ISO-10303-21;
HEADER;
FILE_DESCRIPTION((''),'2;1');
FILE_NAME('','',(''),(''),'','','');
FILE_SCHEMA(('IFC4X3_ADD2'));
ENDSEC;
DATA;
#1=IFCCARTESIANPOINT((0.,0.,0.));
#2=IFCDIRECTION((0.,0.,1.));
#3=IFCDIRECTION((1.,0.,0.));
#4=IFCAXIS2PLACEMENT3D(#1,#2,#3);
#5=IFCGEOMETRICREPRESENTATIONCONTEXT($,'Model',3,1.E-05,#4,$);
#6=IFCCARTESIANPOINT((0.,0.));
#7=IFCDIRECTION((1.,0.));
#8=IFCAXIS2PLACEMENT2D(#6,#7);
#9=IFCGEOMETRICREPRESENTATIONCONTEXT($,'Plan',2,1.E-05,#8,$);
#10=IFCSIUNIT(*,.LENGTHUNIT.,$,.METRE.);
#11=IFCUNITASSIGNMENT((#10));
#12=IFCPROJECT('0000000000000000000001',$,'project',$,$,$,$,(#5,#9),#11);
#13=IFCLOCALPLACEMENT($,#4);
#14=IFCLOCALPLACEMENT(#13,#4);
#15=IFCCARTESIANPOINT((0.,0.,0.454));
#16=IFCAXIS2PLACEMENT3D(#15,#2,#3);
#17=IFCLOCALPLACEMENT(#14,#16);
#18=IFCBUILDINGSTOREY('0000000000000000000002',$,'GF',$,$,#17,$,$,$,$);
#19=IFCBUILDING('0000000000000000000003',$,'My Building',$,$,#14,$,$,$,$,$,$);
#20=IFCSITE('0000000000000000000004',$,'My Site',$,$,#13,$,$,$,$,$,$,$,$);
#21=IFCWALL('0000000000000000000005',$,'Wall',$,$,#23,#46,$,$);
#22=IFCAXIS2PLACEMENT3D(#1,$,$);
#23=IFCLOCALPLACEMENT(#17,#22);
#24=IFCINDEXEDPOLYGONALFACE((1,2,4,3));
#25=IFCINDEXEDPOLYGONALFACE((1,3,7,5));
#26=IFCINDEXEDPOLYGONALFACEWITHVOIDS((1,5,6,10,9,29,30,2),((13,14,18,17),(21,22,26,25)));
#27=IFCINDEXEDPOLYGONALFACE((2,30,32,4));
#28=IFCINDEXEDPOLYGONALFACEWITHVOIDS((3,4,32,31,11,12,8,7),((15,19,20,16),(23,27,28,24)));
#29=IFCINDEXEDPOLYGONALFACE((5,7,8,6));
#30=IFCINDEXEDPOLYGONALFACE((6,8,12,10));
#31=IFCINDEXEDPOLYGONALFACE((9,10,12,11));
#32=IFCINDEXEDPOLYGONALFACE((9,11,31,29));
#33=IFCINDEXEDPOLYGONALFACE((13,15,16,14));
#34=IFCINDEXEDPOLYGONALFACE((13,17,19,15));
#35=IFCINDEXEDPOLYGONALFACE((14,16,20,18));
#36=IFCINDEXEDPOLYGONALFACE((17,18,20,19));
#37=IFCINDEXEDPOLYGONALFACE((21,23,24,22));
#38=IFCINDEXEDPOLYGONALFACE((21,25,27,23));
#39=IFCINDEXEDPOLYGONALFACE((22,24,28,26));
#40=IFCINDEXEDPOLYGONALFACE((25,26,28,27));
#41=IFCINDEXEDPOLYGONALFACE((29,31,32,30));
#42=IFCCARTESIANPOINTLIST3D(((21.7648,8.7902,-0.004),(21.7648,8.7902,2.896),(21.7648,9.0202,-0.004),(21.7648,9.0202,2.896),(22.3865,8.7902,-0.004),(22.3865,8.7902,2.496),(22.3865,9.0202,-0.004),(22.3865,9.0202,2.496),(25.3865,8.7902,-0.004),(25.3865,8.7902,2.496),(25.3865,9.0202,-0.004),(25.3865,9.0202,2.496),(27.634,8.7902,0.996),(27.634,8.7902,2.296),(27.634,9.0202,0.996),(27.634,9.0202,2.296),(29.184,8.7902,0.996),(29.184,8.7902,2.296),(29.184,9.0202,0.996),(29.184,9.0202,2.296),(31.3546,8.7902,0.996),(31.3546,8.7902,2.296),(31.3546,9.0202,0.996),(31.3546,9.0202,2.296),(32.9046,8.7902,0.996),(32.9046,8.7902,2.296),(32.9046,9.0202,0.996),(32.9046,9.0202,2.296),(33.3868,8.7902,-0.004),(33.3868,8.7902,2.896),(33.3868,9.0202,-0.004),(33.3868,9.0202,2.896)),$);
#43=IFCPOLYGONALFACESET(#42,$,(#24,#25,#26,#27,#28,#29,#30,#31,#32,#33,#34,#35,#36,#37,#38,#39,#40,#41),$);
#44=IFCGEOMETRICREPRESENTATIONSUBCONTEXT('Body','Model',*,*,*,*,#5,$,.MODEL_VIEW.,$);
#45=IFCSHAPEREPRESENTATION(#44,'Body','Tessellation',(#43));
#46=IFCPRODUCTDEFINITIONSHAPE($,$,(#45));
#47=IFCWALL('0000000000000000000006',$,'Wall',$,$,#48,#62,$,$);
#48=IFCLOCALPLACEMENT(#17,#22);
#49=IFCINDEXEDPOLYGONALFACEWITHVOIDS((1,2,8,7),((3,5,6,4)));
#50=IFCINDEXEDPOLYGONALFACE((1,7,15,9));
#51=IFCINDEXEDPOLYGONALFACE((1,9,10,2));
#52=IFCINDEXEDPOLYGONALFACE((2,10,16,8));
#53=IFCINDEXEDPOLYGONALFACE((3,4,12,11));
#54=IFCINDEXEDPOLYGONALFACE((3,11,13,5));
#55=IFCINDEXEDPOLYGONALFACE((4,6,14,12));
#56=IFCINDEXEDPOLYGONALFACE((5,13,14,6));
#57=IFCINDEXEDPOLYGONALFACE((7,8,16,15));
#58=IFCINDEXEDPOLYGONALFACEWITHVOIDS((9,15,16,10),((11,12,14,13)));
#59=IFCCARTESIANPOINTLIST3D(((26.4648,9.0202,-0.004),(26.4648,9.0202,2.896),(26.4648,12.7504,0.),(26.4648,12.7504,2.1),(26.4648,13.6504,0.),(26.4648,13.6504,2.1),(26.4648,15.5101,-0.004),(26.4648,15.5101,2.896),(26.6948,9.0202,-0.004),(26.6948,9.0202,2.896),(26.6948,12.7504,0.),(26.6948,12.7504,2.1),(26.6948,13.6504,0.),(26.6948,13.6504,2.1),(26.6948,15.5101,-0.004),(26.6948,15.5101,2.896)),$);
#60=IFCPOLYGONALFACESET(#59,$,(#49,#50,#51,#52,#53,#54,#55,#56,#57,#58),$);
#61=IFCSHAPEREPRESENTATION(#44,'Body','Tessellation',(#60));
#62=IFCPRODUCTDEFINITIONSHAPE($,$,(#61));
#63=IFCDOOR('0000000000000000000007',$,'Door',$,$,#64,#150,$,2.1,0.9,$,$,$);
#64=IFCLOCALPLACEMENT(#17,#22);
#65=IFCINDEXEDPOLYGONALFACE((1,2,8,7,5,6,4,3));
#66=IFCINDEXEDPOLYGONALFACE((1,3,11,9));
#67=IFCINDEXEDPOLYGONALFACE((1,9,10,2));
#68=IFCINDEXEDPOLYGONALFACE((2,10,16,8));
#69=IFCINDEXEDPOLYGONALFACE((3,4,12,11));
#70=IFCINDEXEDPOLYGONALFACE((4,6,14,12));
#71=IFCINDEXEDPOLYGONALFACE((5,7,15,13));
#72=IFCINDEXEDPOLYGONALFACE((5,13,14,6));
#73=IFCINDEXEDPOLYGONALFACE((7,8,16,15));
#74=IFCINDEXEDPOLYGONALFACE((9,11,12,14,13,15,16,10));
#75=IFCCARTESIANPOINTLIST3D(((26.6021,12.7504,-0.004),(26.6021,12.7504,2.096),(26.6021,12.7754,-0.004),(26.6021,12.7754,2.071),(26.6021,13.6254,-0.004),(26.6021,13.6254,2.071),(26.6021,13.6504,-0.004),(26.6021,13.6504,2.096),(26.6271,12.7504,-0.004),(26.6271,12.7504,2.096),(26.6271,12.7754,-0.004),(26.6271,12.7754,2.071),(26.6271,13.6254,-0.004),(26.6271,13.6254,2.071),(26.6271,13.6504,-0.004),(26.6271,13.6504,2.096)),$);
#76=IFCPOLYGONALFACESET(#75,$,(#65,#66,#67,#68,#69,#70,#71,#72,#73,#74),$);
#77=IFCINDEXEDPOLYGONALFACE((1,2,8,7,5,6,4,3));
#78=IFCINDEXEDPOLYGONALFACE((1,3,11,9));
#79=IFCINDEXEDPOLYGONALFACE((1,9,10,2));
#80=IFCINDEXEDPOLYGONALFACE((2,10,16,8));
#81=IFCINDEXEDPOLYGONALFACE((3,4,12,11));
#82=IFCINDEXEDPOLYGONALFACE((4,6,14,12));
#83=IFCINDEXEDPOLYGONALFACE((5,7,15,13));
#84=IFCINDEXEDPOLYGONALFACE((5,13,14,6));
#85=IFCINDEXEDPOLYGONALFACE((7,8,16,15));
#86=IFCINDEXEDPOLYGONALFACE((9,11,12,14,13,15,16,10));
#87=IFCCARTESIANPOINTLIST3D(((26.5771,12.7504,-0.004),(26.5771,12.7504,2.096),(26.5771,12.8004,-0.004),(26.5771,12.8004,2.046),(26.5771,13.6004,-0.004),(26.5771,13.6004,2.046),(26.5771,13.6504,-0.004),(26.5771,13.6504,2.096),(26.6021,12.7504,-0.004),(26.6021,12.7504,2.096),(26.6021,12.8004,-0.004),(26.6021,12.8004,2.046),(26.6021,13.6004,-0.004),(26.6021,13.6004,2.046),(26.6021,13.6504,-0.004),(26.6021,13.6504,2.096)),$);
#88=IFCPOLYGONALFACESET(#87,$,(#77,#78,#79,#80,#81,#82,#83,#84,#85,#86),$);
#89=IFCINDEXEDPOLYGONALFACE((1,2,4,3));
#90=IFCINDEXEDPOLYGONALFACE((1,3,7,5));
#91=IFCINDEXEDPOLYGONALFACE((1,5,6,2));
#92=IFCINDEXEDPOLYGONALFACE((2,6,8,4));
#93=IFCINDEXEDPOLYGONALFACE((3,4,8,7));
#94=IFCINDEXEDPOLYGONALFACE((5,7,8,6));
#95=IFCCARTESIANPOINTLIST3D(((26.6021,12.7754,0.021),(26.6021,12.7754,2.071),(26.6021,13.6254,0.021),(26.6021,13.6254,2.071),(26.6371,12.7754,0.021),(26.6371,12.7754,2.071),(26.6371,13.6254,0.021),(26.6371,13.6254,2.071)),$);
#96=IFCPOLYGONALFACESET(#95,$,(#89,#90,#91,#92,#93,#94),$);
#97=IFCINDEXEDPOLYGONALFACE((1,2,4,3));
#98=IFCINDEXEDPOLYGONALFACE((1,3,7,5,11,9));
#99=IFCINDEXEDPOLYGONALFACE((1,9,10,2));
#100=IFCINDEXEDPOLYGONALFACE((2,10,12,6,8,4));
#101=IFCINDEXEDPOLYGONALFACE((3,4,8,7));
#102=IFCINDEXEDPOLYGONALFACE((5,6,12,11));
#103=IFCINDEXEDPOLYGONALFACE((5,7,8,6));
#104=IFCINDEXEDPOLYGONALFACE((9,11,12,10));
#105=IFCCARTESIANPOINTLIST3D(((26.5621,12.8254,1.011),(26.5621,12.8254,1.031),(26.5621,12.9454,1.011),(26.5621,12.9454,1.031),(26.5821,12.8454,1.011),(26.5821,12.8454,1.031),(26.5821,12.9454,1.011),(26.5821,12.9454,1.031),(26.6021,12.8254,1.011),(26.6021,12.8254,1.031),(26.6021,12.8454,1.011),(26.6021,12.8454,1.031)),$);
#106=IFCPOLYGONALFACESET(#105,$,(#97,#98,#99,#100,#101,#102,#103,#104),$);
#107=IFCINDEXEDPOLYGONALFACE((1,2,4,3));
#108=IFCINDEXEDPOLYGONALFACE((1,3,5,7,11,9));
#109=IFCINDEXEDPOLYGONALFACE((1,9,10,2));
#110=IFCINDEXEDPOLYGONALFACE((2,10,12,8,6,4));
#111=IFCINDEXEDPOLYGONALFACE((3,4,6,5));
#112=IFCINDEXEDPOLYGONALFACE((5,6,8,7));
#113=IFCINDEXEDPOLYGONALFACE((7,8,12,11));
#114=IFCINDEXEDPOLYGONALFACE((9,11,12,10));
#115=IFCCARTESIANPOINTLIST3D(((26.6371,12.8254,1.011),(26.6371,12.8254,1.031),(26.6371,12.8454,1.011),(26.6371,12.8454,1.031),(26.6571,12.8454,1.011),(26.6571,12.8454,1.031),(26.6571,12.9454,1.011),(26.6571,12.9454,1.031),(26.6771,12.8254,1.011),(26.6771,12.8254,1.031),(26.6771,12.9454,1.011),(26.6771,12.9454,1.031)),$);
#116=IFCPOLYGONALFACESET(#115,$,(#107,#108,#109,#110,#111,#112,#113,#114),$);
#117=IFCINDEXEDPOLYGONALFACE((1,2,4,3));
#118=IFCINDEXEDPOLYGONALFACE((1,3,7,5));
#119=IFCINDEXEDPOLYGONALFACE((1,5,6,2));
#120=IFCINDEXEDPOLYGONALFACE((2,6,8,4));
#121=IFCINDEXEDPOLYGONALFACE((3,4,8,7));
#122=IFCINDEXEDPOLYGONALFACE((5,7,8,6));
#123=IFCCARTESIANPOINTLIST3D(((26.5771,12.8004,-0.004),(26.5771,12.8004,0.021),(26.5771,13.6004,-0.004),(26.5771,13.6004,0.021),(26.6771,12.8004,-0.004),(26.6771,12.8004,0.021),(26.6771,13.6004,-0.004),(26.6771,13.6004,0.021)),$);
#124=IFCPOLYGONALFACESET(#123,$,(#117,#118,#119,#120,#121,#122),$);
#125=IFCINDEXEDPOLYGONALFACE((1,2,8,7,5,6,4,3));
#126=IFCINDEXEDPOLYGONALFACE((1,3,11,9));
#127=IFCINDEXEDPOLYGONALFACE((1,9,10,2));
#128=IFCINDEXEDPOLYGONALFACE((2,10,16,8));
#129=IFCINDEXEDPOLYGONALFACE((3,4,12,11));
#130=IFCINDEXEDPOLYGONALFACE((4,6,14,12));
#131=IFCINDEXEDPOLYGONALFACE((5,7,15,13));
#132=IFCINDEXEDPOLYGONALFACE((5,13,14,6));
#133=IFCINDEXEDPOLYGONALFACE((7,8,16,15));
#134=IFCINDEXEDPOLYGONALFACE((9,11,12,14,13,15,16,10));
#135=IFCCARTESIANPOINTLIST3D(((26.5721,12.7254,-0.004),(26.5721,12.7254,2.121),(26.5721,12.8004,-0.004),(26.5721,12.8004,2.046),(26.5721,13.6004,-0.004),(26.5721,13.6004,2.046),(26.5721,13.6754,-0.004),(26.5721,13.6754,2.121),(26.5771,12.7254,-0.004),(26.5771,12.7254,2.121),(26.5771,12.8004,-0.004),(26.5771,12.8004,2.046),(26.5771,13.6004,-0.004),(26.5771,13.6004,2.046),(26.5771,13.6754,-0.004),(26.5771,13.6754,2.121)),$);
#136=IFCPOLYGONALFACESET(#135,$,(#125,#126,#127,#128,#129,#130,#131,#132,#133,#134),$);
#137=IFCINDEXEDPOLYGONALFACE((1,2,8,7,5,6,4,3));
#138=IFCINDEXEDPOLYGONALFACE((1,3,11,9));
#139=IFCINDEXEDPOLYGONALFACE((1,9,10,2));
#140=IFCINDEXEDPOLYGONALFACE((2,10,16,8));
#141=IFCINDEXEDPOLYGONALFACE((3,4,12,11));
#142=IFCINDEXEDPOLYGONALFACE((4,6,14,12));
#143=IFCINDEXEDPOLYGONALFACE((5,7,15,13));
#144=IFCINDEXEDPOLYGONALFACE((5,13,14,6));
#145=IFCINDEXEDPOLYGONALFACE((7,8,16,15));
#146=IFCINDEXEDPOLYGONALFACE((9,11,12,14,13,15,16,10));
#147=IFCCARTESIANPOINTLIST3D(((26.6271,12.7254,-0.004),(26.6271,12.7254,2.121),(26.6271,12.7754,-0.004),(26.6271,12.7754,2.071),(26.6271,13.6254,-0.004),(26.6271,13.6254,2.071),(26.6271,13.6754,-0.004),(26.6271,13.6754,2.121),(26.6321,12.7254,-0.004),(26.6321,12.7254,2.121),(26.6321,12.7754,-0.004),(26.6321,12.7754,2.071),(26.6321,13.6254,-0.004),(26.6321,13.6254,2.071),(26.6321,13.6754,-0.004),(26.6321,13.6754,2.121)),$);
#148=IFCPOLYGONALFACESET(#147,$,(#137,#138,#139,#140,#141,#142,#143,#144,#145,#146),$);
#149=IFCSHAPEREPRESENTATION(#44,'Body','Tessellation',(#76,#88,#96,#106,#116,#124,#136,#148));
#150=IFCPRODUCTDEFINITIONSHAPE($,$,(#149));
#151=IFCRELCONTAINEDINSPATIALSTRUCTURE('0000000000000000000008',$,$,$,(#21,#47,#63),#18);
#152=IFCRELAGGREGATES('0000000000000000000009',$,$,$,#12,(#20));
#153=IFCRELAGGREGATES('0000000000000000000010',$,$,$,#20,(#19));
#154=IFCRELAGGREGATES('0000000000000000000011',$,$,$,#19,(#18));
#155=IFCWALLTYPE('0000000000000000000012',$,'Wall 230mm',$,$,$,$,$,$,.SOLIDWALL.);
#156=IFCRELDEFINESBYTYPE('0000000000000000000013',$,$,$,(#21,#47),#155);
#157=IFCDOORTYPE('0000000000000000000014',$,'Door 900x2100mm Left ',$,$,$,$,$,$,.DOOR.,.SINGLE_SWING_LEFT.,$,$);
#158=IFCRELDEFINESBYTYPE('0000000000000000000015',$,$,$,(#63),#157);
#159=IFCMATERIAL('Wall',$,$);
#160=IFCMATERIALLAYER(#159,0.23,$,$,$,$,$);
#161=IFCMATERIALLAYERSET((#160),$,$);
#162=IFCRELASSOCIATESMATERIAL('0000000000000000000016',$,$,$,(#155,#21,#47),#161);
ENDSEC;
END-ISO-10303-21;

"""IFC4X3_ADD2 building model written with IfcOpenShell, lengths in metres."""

from ifc_helpers import new_model, entity, si_unit, frame, origin_with_axes, origin_2d_with_axis, place, context, subcontext, project, spatial, line, indexed_curve, outline, extrude, shape, source, transform, mapped, material, layer, layer_set, layer_usage, type_object, type_shapes, element, fill, save


model = new_model("IFC4X3_ADD2")

# Units and contexts
model_context = context("Model", 3, precision=1e-05, world=origin_with_axes())
plan_context = context("Plan", 2, precision=1e-05, world=origin_2d_with_axis())
body_context_1 = subcontext(model_context, "Body", "Model", "MODEL_VIEW")
body_context_2 = subcontext(plan_context, "Body", "Plan", "PLAN_VIEW")
ifc_project = project(units=[si_unit("LENGTHUNIT", "METRE")], contexts=[model_context, plan_context])

# Site, building, storey
site_placement = place(None, origin_with_axes())
site = spatial("IfcSite", under=ifc_project, at=site_placement, Name="My Site")
building_placement = place(site_placement, origin_with_axes())
building = spatial("IfcBuilding", under=site, at=building_placement, Name="My Building")
storey_placement = place(building_placement, frame((0.0, 0.0, 0.454), z_axis=(0.0, 0.0, 1.0), x_axis=(1.0, 0.0, 0.0)))
storey = spatial("IfcBuildingStorey", under=building, at=storey_placement, Name="GF")

# Shared definitions
ifc_material_1 = material(Name="Wall")
ifc_layer = layer(ifc_material_1, 0.23)
ifc_layer_set = layer_set([ifc_layer])
wall_type = type_object("IfcWallType", Name="Wall 230mm", PredefinedType="SOLIDWALL", material=ifc_layer_set)

# Wall, openings
ifc_layer_usage_1 = layer_usage(ifc_layer_set, "AXIS2", "POSITIVE", 0.0)
wall_1_placement = place(storey_placement, frame((33.3868, 9.0202, -0.004), z_axis=(0.0, 0.0, 1.0), x_axis=(-1.0, 0.0, 0.0)))
wall_1 = element("IfcWall", 1, at=wall_1_placement, inside=storey, type_object=wall_type, material=ifc_layer_usage_1, Name="Wall", context=body_context_1, shape_type="SweptSolid", body=[
    extrude(outline(indexed_curve([(0.0, 0.0), (0.0, 0.23), (11.622, 0.23), (11.622, 0.0), (0.0, 0.0)], self_intersect=False)), origin_with_axes(), (0.0, 0.0, 1.0), 2.9),
])
shared_shape_1 = source(origin_with_axes(), body_context_1, "Body", "SweptSolid", [
    extrude(outline(indexed_curve([(0.0, 0.0), (3.0, 0.0), (3.0, 2.5), (0.0, 2.5)], segments=[line(1, 2, 3, 4, 1)])), frame((0.0, -0.6, 0.0), z_axis=(0.0, -1.0, 0.0), x_axis=(1.0, 0.0, 0.0)), (0.0, 0.0, -1.0), 1.2),
])
opening_1_placement = place(wall_1_placement, frame((8.0003, 0.0, 0.0), z_axis=(0.0, 0.0, 1.0), x_axis=(1.0, 0.0, 0.0)))
element("IfcOpeningElement", 2, at=opening_1_placement, cuts=wall_1, PredefinedType="OPENING", context=body_context_1, shape_type="MappedRepresentation", body=[
    mapped(shared_shape_1, transform((0.0, 0.0, 0.0), x_axis=(1.0, 0.0, 0.0), y_axis=(0.0, 1.0, 0.0), z_axis=(0.0, 0.0, 1.0), scale=1.0)),
])
shared_shape_2 = source(origin_with_axes(), body_context_1, "Body", "SweptSolid", [
    extrude(outline(indexed_curve([(0.0, 0.0), (1.55, 0.0), (1.55, 1.3), (0.0, 1.3)], segments=[line(1, 2, 3, 4, 1)])), frame((-0.775, -0.6, 0.0), z_axis=(0.0, -1.0, 0.0), x_axis=(1.0, 0.0, 0.0)), (0.0, 0.0, -1.0), 1.2),
])
opening_2_placement = place(wall_1_placement, frame((1.2571, 0.0, 1.0), z_axis=(0.0, 0.0, 1.0), x_axis=(1.0, 0.0, 0.0)))
element("IfcOpeningElement", 3, at=opening_2_placement, cuts=wall_1, PredefinedType="OPENING", context=body_context_1, shape_type="MappedRepresentation", body=[
    mapped(shared_shape_2, transform((0.0, 0.0, 0.0), x_axis=(1.0, 0.0, 0.0), y_axis=(0.0, 1.0, 0.0), z_axis=(0.0, 0.0, 1.0), scale=1.0)),
])
opening_3_placement = place(wall_1_placement, frame((4.9778, 0.0, 1.0), z_axis=(0.0, 0.0, 1.0), x_axis=(1.0, 0.0, 0.0)))
element("IfcOpeningElement", 4, at=opening_3_placement, cuts=wall_1, PredefinedType="OPENING", context=body_context_1, shape_type="MappedRepresentation", body=[
    mapped(shared_shape_2, transform((0.0, 0.0, 0.0), x_axis=(1.0, 0.0, 0.0), y_axis=(0.0, 1.0, 0.0), z_axis=(0.0, 0.0, 1.0), scale=1.0)),
])

# Wall, opening, door
ifc_layer_usage_2 = layer_usage(ifc_layer_set, "AXIS2", "POSITIVE", 0.0)
wall_2_placement = place(storey_placement, frame((26.6948, 9.0202, -0.004), z_axis=(0.0, 0.0, 1.0), x_axis=(0.000001, 1.0, 0.0)))
wall_2 = element("IfcWall", 5, at=wall_2_placement, inside=storey, type_object=wall_type, material=ifc_layer_usage_2, Name="Wall", context=body_context_1, shape_type="SweptSolid", body=[
    extrude(outline(indexed_curve([(0.0, 0.0), (0.0, 0.23), (6.4899, 0.23), (6.4899, 0.0), (0.0, 0.0)], self_intersect=False)), origin_with_axes(), (0.0, 0.0, 1.0), 2.9),
])
shared_shape_3 = source(origin_with_axes(), body_context_1, "Body", "SweptSolid", [
    extrude(outline(indexed_curve([(0.0, 0.0), (0.9, 0.0), (0.9, 2.1), (0.0, 2.1)], segments=[line(1, 2, 3, 4, 1)])), frame((0.0, -0.6, 0.0), z_axis=(0.0, -1.0, 0.0), x_axis=(1.0, 0.0, 0.0)), (0.0, 0.0, -1.0), 1.2),
])
opening_4_placement = place(wall_2_placement, frame((4.6302, 0.1177, 0.004), z_axis=(0.0, 0.0, 1.0), x_axis=(-1.0, 0.0, 0.0)))
opening_4 = element("IfcOpeningElement", 6, at=opening_4_placement, cuts=wall_2, PredefinedType="OPENING", context=body_context_1, shape_type="MappedRepresentation", body=[
    mapped(shared_shape_3, transform((0.0, 0.0, 0.0), x_axis=(1.0, 0.0, 0.0), y_axis=(0.0, 1.0, 0.0), z_axis=(0.0, 0.0, 1.0), scale=1.0)),
])
door_type_1 = type_object("IfcDoorType", Name="Door 900x2100mm Left ", OperationType="SINGLE_SWING_LEFT", PredefinedType="DOOR")
shared_shape_4 = source(origin_with_axes(), body_context_1, "Body", "SweptSolid", [
    extrude(outline(indexed_curve([(0.0, 0.0), (0.0, 2.1), (0.9, 2.1), (0.9, 0.0), (0.875, 0.0), (0.875, 2.075), (0.025, 2.075), (0.025, 0.0)], segments=[line(1, 2, 3, 4, 5, 6, 7, 8, 1)])), frame((0.0, 0.025, 0.0), z_axis=(0.0, -1.0, 0.0), x_axis=(1.0, 0.0, 0.0)), (0.0, 0.0, -1.0), 0.025),
    extrude(outline(indexed_curve([(0.0, 0.0), (0.0, 2.1), (0.9, 2.1), (0.9, 0.0), (0.85, 0.0), (0.85, 2.05), (0.05, 2.05), (0.05, 0.0)], segments=[line(1, 2, 3, 4, 5, 6, 7, 8, 1)])), frame((0.0, 0.0, 0.0), z_axis=(0.0, -1.0, 0.0), x_axis=(1.0, 0.0, 0.0)), (0.0, 0.0, -1.0), 0.025),
    extrude(outline(indexed_curve([(0.0, 0.0), (0.85, 0.0), (0.85, 0.035), (0.0, 0.035)], segments=[line(1, 2, 3, 4, 1)])), frame((0.025, 0.025, 0.025), z_axis=(0.0, 0.0, 1.0), x_axis=(1.0, 0.0, 0.0)), (0.0, 0.0, 1.0), 2.05),
    extrude(outline(indexed_curve([(0.0, 0.0), (0.0, -0.04), (-0.12, -0.04), (-0.12, -0.02), (-0.02, -0.02), (-0.02, 0.0)], segments=[line(1, 2, 3, 4, 5, 6, 1)])), frame((0.825, 0.025, 1.015), z_axis=(0.0, 0.0, 1.0), x_axis=(1.0, 0.0, 0.0)), (0.0, 0.0, 1.0), 0.02),
    extrude(outline(indexed_curve([(0.0, 0.0), (0.0, 0.04), (-0.12, 0.04), (-0.12, 0.02), (-0.02, 0.02), (-0.02, 0.0)], segments=[line(1, 2, 3, 4, 5, 6, 1)])), frame((0.825, 0.06, 1.015), z_axis=(0.0, 0.0, 1.0), x_axis=(1.0, 0.0, 0.0)), (0.0, 0.0, 1.0), 0.02),
    extrude(outline(indexed_curve([(0.0, 0.0), (0.8, 0.0), (0.8, 0.1), (0.0, 0.1)], segments=[line(1, 2, 3, 4, 1)])), frame((0.05, 0.0, 0.0), z_axis=(0.0, 0.0, 1.0), x_axis=(1.0, 0.0, 0.0)), (0.0, 0.0, 1.0), 0.025),
    extrude(outline(indexed_curve([(0.0, 0.0), (0.0, 2.125), (0.95, 2.125), (0.95, 0.0), (0.875, 0.0), (0.875, 2.05), (0.075, 2.05), (0.075, 0.0)], segments=[line(1, 2, 3, 4, 5, 6, 7, 8, 1)])), frame((-0.025, -0.005, 0.0), z_axis=(0.0, -1.0, 0.0), x_axis=(1.0, 0.0, 0.0)), (0.0, 0.0, -1.0), 0.005),
    extrude(outline(indexed_curve([(0.0, 0.0), (0.0, 2.125), (0.95, 2.125), (0.95, 0.0), (0.9, 0.0), (0.9, 2.075), (0.05, 2.075), (0.05, 0.0)], segments=[line(1, 2, 3, 4, 5, 6, 7, 8, 1)])), frame((-0.025, 0.05, 0.0), z_axis=(0.0, -1.0, 0.0), x_axis=(1.0, 0.0, 0.0)), (0.0, 0.0, -1.0), 0.005),
])
shared_shape_5 = source(origin_with_axes(), body_context_2, "Body", "Curve2D", [
    entity("IfcIndexedPolyCurve", entity("IfcCartesianPointList2D", [[0.0, 0.0], [0.0, 0.05], [0.025, 0.05], [0.025, 0.025], [0.05, 0.025], [0.05, 0.0]]), [entity("IfcLineIndex", [1, 2, 3, 4, 5, 6, 1])]),
    entity("IfcIndexedPolyCurve", entity("IfcCartesianPointList2D", [[0.9, 0.0], [0.9, 0.05], [0.875, 0.05], [0.875, 0.025], [0.85, 0.025], [0.85, 0.0]]), [entity("IfcLineIndex", [1, 2, 3, 4, 5, 6, 1])]),
    entity("IfcTrimmedCurve", entity("IfcEllipse", entity("IfcAxis2Placement2D", entity("IfcCartesianPoint", [0.06, 0.05]), entity("IfcDirection", [1.0, 0.0])), 0.815, 0.85), [entity("IfcCartesianPoint", [0.875, 0.05])], [entity("IfcCartesianPoint", [0.06, 0.9])], True, "CARTESIAN"),
    entity("IfcIndexedPolyCurve", entity("IfcCartesianPointList2D", [[0.025, 0.05], [0.06, 0.05], [0.06, 0.9], [0.025, 0.9]]), [entity("IfcLineIndex", [1, 2, 3, 4, 1])]),
])
type_shapes(door_type_1, [shared_shape_4, shared_shape_5])
door_1_placement = place(opening_4_placement, frame((0.0, 0.0, -0.004), z_axis=(0.0, 0.0, 1.0), x_axis=(1.0, 0.0, 0.0)))
door_1 = element("IfcDoor", 7, at=door_1_placement, inside=storey, type_object=door_type_1, Name="Door", OverallHeight=2.1, OverallWidth=0.9, shapes=[
    shape(body_context_1, "Body", "MappedRepresentation", [mapped(shared_shape_4, transform((0.0, 0.0, 0.0), x_axis=(1.0, 0.0, 0.0), y_axis=(0.0, 1.0, 0.0), z_axis=(0.0, 0.0, 1.0), scale=1.0))]),
    shape(body_context_2, "Body", "MappedRepresentation", [mapped(shared_shape_5, transform((0.0, 0.0, 0.0), x_axis=(1.0, 0.0, 0.0), y_axis=(0.0, 1.0, 0.0), z_axis=(0.0, 0.0, 1.0), scale=1.0))]),
])
fill(opening_4, door_1)

save(model, "model.ifc")
